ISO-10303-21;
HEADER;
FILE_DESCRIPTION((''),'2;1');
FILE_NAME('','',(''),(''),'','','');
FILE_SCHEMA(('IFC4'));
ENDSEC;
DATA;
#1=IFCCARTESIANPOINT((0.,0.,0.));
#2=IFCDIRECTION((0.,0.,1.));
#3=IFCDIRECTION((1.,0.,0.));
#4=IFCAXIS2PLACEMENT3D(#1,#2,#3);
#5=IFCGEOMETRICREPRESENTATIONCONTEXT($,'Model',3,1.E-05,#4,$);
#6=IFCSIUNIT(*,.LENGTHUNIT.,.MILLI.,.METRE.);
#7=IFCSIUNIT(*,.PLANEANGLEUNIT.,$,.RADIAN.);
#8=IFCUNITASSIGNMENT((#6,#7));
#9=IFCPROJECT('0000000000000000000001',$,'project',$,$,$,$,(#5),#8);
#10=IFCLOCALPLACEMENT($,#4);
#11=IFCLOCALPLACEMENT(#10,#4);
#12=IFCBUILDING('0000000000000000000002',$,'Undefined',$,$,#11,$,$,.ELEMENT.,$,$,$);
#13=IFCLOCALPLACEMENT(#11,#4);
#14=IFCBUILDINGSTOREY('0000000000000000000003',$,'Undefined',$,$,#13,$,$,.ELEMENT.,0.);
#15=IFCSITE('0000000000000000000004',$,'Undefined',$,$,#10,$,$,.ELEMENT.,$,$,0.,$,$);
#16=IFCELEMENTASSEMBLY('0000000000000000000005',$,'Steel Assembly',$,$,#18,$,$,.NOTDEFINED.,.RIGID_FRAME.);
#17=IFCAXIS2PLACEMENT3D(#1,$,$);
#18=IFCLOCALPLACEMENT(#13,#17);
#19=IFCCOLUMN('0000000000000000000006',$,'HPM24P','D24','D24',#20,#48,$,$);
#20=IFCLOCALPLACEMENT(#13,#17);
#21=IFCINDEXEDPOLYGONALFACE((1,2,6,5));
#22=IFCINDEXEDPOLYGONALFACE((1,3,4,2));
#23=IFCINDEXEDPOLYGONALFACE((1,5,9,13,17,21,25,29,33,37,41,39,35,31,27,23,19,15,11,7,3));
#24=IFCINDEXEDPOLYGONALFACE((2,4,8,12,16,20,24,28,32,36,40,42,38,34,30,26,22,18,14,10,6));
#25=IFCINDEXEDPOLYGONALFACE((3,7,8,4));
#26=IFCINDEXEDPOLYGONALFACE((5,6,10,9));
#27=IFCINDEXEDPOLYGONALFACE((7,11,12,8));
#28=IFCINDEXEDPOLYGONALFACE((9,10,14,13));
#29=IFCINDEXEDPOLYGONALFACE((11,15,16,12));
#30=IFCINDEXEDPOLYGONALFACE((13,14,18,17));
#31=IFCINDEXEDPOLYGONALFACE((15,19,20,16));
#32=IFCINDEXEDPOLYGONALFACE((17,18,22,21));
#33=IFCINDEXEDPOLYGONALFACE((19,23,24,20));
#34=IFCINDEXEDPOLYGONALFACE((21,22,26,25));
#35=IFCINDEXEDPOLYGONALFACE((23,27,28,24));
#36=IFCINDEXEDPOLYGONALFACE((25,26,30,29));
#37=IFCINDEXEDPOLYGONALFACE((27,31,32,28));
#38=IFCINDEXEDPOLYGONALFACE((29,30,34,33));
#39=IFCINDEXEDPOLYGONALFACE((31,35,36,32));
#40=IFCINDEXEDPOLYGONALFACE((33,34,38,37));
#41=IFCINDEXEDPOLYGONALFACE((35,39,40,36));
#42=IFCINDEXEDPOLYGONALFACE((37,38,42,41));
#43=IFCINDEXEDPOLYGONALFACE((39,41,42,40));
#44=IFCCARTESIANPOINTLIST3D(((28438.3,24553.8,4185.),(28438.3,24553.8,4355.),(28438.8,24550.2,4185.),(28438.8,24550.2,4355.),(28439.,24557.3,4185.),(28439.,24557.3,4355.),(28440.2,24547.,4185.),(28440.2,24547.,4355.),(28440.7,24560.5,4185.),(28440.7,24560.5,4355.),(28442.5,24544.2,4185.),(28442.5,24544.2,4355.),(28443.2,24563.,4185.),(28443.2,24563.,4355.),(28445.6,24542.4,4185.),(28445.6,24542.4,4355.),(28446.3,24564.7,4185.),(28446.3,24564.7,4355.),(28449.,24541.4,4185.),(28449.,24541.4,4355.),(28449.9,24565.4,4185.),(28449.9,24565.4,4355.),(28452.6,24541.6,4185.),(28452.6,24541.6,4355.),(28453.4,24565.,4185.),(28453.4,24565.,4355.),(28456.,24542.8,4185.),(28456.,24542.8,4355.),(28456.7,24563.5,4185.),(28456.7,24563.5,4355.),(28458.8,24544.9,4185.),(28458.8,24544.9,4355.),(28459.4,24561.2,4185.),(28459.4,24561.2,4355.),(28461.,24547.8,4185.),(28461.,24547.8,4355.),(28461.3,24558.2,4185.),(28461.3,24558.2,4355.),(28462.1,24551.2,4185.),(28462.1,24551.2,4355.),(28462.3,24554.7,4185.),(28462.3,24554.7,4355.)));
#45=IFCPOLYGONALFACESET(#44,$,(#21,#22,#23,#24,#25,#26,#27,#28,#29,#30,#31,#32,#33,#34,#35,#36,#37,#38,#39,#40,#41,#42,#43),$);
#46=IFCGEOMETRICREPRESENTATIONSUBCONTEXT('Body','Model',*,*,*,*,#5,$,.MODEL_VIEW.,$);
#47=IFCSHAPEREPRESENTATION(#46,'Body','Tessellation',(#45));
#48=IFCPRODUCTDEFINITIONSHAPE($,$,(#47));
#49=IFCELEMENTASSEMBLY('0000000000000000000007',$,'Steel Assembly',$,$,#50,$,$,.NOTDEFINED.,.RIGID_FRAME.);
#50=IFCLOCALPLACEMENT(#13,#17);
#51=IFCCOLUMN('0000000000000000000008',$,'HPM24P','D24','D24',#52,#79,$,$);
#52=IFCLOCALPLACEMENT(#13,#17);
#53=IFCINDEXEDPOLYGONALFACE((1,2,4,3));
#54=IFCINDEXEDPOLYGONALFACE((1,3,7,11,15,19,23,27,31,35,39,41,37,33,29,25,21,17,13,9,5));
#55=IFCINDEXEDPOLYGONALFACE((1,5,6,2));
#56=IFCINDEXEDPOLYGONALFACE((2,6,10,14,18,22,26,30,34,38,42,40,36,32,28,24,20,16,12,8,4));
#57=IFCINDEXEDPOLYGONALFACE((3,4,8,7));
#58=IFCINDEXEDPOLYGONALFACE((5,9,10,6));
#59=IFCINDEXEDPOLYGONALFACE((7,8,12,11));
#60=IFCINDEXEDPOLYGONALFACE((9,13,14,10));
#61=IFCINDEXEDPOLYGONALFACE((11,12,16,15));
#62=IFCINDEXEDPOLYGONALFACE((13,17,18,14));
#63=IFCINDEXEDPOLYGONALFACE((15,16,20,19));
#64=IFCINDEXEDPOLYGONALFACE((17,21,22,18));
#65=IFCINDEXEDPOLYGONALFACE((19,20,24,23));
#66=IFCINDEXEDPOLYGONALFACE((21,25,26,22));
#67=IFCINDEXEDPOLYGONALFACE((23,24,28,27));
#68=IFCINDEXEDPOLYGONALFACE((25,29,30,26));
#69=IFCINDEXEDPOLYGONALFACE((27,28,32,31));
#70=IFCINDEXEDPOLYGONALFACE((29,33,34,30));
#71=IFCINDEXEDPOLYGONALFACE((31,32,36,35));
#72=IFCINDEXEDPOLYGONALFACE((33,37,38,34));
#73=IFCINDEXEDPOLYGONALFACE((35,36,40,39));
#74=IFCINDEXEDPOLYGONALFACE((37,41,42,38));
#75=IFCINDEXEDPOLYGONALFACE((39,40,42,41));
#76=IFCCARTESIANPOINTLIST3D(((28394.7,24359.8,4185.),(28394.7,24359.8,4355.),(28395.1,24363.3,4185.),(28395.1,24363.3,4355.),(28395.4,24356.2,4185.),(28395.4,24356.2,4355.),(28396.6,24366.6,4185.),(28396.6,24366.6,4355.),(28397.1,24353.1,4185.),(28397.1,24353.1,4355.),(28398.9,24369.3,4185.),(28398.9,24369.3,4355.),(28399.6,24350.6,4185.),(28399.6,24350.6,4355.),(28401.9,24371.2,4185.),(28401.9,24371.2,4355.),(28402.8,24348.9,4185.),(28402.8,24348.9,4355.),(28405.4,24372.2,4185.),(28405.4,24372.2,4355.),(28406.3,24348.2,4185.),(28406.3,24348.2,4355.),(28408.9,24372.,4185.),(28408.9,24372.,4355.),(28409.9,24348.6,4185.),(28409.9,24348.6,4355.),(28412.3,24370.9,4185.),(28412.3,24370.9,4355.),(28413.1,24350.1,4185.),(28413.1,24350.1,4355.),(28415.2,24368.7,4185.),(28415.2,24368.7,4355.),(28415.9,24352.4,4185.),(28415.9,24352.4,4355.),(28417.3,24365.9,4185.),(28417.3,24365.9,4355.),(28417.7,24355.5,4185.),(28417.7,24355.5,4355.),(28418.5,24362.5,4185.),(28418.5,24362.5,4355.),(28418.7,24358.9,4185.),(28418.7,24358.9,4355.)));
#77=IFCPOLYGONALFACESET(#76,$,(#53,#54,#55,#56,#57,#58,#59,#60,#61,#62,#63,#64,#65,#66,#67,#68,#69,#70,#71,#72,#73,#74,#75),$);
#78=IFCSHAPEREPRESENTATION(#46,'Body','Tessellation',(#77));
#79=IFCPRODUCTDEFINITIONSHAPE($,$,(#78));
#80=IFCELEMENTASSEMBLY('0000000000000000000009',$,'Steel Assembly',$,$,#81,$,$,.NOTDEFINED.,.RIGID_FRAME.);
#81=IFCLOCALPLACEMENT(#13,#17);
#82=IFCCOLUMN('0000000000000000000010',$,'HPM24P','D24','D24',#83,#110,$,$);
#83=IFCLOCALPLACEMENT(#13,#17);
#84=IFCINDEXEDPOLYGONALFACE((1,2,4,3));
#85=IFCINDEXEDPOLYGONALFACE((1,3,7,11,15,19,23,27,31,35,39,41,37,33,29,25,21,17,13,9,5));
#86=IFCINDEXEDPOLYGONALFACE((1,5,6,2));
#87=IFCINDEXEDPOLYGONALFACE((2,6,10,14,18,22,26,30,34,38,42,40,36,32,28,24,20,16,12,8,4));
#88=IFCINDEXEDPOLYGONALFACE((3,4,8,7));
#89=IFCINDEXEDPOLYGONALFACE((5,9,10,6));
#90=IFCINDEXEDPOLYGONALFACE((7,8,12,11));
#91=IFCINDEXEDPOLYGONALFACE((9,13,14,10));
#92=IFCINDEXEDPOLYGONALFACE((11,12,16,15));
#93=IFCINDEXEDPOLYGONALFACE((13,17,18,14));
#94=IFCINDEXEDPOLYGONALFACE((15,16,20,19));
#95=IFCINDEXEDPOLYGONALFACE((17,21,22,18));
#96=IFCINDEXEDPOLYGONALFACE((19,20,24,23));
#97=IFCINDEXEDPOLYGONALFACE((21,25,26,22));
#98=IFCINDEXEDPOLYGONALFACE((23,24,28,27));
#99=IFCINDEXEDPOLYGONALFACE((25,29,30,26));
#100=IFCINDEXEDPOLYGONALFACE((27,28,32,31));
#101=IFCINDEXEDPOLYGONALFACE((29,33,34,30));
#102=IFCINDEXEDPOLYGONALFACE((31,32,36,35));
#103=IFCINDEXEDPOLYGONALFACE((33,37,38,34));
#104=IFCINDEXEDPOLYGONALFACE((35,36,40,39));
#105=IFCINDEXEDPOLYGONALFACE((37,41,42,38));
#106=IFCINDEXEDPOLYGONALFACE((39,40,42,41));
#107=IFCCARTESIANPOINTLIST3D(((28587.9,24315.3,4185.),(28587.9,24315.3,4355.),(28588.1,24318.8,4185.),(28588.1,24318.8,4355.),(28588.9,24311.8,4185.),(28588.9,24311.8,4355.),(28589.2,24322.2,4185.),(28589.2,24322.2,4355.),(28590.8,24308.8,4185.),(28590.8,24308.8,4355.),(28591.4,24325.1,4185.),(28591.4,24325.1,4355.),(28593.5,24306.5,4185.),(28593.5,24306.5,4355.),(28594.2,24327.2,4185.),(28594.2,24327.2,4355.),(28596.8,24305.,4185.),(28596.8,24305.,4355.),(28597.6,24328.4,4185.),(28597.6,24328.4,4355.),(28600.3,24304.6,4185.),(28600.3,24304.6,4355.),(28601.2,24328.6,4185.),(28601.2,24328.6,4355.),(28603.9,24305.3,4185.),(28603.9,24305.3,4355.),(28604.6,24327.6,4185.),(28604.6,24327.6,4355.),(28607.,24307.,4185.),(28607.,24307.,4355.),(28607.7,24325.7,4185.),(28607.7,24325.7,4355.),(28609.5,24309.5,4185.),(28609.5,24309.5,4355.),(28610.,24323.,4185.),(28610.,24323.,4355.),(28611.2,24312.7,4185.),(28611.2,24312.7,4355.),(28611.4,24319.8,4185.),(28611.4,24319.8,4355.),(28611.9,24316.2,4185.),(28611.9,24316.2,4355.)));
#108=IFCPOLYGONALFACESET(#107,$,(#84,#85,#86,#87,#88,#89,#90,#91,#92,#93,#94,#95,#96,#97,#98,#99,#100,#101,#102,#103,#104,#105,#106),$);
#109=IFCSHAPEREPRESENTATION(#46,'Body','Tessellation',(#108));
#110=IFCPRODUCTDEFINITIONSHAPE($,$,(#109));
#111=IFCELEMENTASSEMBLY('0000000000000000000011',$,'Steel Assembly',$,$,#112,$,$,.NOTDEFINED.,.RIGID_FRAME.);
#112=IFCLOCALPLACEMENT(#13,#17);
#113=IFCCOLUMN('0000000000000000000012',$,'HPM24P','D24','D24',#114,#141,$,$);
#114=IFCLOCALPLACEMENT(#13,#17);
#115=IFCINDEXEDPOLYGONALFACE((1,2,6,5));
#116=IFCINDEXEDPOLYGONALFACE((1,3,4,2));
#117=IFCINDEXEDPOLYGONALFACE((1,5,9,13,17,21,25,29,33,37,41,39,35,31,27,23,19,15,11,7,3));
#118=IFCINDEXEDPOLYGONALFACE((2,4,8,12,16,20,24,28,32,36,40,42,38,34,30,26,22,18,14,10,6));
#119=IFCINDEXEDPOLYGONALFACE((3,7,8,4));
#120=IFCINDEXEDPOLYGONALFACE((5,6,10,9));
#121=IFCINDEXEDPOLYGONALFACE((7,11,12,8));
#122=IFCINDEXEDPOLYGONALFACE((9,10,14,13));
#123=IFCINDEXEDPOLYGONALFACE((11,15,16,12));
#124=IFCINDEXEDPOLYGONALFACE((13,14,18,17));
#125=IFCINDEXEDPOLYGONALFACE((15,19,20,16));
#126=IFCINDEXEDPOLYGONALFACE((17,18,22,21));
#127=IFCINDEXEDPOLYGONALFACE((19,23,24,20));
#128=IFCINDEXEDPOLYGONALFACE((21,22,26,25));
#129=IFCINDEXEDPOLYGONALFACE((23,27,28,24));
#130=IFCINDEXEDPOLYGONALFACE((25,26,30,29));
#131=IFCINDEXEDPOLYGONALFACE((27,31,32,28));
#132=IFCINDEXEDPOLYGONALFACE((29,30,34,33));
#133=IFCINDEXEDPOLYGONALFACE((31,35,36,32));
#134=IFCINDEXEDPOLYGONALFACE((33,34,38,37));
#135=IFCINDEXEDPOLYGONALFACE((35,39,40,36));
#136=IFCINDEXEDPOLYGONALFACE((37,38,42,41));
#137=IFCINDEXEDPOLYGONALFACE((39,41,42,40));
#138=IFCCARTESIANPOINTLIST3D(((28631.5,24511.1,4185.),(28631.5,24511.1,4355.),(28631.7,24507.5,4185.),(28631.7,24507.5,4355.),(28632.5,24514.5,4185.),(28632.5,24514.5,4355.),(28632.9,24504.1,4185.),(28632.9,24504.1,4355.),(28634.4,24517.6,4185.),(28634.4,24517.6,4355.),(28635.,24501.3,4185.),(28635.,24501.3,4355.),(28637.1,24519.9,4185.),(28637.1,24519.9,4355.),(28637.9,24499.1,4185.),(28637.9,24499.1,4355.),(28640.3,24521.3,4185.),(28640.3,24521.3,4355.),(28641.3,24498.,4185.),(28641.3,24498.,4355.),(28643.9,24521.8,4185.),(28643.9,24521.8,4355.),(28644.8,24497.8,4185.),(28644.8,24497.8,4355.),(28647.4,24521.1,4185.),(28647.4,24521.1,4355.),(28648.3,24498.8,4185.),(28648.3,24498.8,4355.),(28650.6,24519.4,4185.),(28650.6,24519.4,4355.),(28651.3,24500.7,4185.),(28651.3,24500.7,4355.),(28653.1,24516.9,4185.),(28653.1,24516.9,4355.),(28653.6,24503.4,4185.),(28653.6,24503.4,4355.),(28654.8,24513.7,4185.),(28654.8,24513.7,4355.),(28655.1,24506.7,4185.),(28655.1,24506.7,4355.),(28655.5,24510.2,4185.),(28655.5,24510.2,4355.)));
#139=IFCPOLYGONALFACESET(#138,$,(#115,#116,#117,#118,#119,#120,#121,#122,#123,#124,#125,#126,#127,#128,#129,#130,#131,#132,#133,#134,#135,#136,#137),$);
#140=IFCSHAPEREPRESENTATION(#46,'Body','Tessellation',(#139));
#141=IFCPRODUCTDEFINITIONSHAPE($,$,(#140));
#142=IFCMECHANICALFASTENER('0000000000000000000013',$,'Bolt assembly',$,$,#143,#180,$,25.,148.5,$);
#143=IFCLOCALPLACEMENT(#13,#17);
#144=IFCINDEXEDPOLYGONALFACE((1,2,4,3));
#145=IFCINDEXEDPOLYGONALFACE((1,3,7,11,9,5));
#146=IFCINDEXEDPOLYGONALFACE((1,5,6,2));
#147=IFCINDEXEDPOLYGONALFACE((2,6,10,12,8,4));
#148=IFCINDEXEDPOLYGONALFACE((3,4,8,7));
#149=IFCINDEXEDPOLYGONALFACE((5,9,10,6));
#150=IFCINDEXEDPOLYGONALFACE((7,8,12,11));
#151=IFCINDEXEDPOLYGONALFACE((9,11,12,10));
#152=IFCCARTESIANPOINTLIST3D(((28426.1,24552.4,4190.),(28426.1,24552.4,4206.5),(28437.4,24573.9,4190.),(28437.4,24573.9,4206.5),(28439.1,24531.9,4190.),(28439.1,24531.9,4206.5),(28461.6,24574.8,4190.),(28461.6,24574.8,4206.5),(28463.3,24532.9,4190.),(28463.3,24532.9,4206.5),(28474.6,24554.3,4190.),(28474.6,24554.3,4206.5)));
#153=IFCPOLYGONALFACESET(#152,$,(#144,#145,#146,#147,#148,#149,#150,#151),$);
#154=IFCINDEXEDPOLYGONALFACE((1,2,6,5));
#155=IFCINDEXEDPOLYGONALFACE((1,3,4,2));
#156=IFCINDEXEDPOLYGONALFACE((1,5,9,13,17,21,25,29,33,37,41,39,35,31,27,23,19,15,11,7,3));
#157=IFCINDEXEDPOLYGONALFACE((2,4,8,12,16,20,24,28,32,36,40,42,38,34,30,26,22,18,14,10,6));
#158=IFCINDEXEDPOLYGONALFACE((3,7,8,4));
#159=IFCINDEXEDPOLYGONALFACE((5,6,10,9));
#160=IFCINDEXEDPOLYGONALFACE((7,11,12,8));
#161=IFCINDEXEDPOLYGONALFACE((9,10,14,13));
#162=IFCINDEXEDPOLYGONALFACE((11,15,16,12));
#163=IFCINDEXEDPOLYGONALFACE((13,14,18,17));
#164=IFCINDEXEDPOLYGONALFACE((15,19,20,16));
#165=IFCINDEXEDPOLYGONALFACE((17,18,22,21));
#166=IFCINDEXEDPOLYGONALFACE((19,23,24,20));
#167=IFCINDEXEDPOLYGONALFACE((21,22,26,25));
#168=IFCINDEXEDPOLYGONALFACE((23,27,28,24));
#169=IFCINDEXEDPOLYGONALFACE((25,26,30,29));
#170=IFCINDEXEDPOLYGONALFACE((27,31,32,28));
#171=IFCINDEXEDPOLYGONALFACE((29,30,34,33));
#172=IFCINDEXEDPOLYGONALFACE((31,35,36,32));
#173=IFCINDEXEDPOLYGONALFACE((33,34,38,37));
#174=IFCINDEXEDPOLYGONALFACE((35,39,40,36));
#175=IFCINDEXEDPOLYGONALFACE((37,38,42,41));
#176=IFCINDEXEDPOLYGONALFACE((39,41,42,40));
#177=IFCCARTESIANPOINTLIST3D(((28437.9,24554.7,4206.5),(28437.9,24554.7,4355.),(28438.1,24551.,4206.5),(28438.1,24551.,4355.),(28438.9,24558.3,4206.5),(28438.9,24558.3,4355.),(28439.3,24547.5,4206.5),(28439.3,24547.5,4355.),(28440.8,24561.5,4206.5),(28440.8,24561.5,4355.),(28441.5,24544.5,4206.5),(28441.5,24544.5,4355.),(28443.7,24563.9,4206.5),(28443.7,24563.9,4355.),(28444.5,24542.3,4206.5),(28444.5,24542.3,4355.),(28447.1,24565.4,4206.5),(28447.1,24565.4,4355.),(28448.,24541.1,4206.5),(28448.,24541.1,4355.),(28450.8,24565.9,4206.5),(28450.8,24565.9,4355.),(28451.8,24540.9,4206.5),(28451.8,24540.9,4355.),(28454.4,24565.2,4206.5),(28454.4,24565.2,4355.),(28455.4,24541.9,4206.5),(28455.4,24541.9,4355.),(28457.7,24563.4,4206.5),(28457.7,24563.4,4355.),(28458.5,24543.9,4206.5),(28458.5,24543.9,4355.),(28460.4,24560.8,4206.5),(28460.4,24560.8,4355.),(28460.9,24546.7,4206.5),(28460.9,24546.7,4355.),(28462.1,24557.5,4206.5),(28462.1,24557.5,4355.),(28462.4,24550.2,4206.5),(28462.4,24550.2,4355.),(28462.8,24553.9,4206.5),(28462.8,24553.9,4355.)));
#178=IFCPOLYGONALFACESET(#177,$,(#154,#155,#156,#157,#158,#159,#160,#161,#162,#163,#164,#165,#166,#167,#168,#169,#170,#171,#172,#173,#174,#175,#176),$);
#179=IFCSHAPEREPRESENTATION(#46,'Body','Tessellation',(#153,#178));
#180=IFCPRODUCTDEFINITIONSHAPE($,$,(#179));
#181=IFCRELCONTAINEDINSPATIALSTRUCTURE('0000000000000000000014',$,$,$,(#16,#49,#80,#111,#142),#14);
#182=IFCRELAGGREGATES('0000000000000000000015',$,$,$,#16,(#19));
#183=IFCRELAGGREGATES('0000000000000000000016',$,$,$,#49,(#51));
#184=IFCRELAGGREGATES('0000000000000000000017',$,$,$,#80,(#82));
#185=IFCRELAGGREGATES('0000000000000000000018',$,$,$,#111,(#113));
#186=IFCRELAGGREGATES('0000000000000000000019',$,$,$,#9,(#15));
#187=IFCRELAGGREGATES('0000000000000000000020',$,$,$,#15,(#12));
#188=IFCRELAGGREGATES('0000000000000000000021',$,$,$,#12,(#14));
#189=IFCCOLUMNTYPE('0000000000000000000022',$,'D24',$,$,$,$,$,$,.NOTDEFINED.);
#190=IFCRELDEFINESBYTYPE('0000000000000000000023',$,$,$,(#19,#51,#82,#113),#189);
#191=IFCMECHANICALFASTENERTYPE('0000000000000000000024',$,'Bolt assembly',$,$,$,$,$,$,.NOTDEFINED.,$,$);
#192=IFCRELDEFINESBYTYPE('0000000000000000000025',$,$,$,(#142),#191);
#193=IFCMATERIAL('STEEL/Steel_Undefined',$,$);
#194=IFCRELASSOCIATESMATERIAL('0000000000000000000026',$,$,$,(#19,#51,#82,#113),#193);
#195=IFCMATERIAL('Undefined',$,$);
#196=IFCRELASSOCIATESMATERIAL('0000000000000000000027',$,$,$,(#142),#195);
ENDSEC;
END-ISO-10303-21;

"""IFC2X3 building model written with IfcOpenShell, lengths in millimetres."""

from ifc_helpers import new_model, si_unit, frame, origin_with_axes, origin_2d_with_axis, place, context, subcontext, project, spatial, polyline, circle, outline, extrude, source, transform, mapped, material, type_object, element, aggregate, save


model = new_model("IFC2X3")

# Units and contexts
model_context = context("Model", 3, precision=1e-05, world=origin_with_axes())
body_context = subcontext(model_context, "Body", "Model", "MODEL_VIEW")
ifc_project = project(units=[si_unit("LENGTHUNIT", "METRE", prefix="MILLI"), si_unit("PLANEANGLEUNIT", "RADIAN")], contexts=[model_context])

# Site, building, storey
site_placement = place(None, origin_with_axes())
site = spatial("IfcSite", under=ifc_project, at=site_placement, Name="Undefined", CompositionType="ELEMENT", RefElevation=0.0)
building_placement = place(site_placement, origin_with_axes())
building = spatial("IfcBuilding", under=site, at=building_placement, Name="Undefined", CompositionType="ELEMENT")
storey_placement = place(building_placement, origin_with_axes())
storey = spatial("IfcBuildingStorey", under=building, at=storey_placement, Name="Undefined", CompositionType="ELEMENT", Elevation=0.0)

# Element assemblies, columns
assembly_1_placement = place(storey_placement, origin_with_axes())
assembly_1 = element("IfcElementAssembly", 1, at=assembly_1_placement, inside=storey, Name="Steel Assembly", AssemblyPlace="NOTDEFINED", PredefinedType="RIGID_FRAME")
ifc_material_1 = material(Name="STEEL/Steel_Undefined")
column_type = type_object("IfcColumnType", Name="D24", PredefinedType="NOTDEFINED")
column_1_placement = place(assembly_1_placement, frame((28450.3, 24553.4, 4185.0), z_axis=(0.0, 0.0, 1.0), x_axis=(-0.534023, 0.84547, 0.0)))
column_1 = element("IfcColumn", 2, at=column_1_placement, type_object=column_type, material=ifc_material_1, Name="HPM24P", Description="D24", ObjectType="D24", context=body_context, shape_type="SweptSolid", body=[
    extrude(circle(Radius=12.0, at=origin_2d_with_axis()), frame((0.0, 0.0, 170.0), z_axis=(0.0, 0.0, -1.0), x_axis=(0.0, 1.0, 0.0)), (0.0, 0.0, 1.0), 170.0),
])
assembly_2_placement = place(storey_placement, origin_with_axes())
assembly_2 = element("IfcElementAssembly", 3, at=assembly_2_placement, inside=storey, Name="Steel Assembly", AssemblyPlace="NOTDEFINED", PredefinedType="RIGID_FRAME")
column_2_placement = place(assembly_2_placement, frame((28406.7, 24360.2, 4185.0), z_axis=(0.0, 0.0, 1.0), x_axis=(-0.84547, -0.534023, 0.0)))
column_2 = element("IfcColumn", 4, at=column_2_placement, type_object=column_type, material=ifc_material_1, Name="HPM24P", Description="D24", ObjectType="D24", context=body_context, shape_type="SweptSolid", body=[
    extrude(circle(Radius=12.0, at=origin_2d_with_axis()), frame((0.0, 0.0, 170.0), z_axis=(0.0, 0.0, -1.0), x_axis=(0.0, 1.0, 0.0)), (0.0, 0.0, 1.0), 170.0),
])
assembly_3_placement = place(storey_placement, origin_with_axes())
assembly_3 = element("IfcElementAssembly", 5, at=assembly_3_placement, inside=storey, Name="Steel Assembly", AssemblyPlace="NOTDEFINED", PredefinedType="RIGID_FRAME")
column_3_placement = place(assembly_3_placement, frame((28599.9, 24316.6, 4185.0), z_axis=(0.0, 0.0, 1.0), x_axis=(0.534023, -0.84547, 0.0)))
column_3 = element("IfcColumn", 6, at=column_3_placement, type_object=column_type, material=ifc_material_1, Name="HPM24P", Description="D24", ObjectType="D24", context=body_context, shape_type="SweptSolid", body=[
    extrude(circle(Radius=12.0, at=origin_2d_with_axis()), frame((0.0, 0.0, 170.0), z_axis=(0.0, 0.0, -1.0), x_axis=(0.0, 1.0, 0.0)), (0.0, 0.0, 1.0), 170.0),
])
assembly_4_placement = place(storey_placement, origin_with_axes())
assembly_4 = element("IfcElementAssembly", 7, at=assembly_4_placement, inside=storey, Name="Steel Assembly", AssemblyPlace="NOTDEFINED", PredefinedType="RIGID_FRAME")
column_4_placement = place(assembly_4_placement, frame((28643.5, 24509.8, 4185.0), z_axis=(0.0, 0.0, 1.0), x_axis=(0.84547, 0.534023, 0.0)))
column_4 = element("IfcColumn", 8, at=column_4_placement, type_object=column_type, material=ifc_material_1, Name="HPM24P", Description="D24", ObjectType="D24", context=body_context, shape_type="SweptSolid", body=[
    extrude(circle(Radius=12.0, at=origin_2d_with_axis()), frame((0.0, 0.0, 170.0), z_axis=(0.0, 0.0, -1.0), x_axis=(0.0, 1.0, 0.0)), (0.0, 0.0, 1.0), 170.0),
])

# Mechanical fastener
ifc_material_2 = material(Name="Undefined")
mechanical_fastener_type = type_object("IfcMechanicalFastenerType", Name="Bolt assembly")
shared_shape_1 = source(origin_with_axes(), body_context, "Body", "SweptSolid", [
    extrude(outline(polyline([(24.2, 0.0), (12.1, 21.0), (-12.1, 21.0), (-24.2, 0.0), (-12.1, -21.0), (12.1, -21.0), (24.2, 0.0)])), frame((0.0, -165.0, 0.0), z_axis=(0.0, 1.0, 0.0), x_axis=(1.0, 0.0, 0.0)), (0.0, 0.0, 1.0), 16.5),
    extrude(circle(Radius=12.5, at=origin_2d_with_axis()), frame((0.0, -148.5, 0.0), z_axis=(0.0, 1.0, 0.0), x_axis=(1.0, 0.0, 0.0)), (0.0, 0.0, 1.0), 148.5),
])
for number, where, z_axis, x_axis, name in (
    (9, (28450.3, 24553.4, 4355.0), (0.84547, 0.534023, 0.0), (-0.534023, 0.84547, 0.0), "Bolt assembly"),
):
    element("IfcMechanicalFastener", number, at=place(storey_placement, frame(where, z_axis=z_axis, x_axis=x_axis)), inside=storey, type_object=mechanical_fastener_type, material=ifc_material_2, Name=name, NominalDiameter=25.0, NominalLength=148.5, context=body_context, shape_type="MappedRepresentation", body=[
        mapped(shared_shape_1, transform((0.0, 0.0, 0.0))),
    ])

aggregate(assembly_1, [column_1])
aggregate(assembly_2, [column_2])
aggregate(assembly_3, [column_3])
aggregate(assembly_4, [column_4])

save(model, "model.ifc")
